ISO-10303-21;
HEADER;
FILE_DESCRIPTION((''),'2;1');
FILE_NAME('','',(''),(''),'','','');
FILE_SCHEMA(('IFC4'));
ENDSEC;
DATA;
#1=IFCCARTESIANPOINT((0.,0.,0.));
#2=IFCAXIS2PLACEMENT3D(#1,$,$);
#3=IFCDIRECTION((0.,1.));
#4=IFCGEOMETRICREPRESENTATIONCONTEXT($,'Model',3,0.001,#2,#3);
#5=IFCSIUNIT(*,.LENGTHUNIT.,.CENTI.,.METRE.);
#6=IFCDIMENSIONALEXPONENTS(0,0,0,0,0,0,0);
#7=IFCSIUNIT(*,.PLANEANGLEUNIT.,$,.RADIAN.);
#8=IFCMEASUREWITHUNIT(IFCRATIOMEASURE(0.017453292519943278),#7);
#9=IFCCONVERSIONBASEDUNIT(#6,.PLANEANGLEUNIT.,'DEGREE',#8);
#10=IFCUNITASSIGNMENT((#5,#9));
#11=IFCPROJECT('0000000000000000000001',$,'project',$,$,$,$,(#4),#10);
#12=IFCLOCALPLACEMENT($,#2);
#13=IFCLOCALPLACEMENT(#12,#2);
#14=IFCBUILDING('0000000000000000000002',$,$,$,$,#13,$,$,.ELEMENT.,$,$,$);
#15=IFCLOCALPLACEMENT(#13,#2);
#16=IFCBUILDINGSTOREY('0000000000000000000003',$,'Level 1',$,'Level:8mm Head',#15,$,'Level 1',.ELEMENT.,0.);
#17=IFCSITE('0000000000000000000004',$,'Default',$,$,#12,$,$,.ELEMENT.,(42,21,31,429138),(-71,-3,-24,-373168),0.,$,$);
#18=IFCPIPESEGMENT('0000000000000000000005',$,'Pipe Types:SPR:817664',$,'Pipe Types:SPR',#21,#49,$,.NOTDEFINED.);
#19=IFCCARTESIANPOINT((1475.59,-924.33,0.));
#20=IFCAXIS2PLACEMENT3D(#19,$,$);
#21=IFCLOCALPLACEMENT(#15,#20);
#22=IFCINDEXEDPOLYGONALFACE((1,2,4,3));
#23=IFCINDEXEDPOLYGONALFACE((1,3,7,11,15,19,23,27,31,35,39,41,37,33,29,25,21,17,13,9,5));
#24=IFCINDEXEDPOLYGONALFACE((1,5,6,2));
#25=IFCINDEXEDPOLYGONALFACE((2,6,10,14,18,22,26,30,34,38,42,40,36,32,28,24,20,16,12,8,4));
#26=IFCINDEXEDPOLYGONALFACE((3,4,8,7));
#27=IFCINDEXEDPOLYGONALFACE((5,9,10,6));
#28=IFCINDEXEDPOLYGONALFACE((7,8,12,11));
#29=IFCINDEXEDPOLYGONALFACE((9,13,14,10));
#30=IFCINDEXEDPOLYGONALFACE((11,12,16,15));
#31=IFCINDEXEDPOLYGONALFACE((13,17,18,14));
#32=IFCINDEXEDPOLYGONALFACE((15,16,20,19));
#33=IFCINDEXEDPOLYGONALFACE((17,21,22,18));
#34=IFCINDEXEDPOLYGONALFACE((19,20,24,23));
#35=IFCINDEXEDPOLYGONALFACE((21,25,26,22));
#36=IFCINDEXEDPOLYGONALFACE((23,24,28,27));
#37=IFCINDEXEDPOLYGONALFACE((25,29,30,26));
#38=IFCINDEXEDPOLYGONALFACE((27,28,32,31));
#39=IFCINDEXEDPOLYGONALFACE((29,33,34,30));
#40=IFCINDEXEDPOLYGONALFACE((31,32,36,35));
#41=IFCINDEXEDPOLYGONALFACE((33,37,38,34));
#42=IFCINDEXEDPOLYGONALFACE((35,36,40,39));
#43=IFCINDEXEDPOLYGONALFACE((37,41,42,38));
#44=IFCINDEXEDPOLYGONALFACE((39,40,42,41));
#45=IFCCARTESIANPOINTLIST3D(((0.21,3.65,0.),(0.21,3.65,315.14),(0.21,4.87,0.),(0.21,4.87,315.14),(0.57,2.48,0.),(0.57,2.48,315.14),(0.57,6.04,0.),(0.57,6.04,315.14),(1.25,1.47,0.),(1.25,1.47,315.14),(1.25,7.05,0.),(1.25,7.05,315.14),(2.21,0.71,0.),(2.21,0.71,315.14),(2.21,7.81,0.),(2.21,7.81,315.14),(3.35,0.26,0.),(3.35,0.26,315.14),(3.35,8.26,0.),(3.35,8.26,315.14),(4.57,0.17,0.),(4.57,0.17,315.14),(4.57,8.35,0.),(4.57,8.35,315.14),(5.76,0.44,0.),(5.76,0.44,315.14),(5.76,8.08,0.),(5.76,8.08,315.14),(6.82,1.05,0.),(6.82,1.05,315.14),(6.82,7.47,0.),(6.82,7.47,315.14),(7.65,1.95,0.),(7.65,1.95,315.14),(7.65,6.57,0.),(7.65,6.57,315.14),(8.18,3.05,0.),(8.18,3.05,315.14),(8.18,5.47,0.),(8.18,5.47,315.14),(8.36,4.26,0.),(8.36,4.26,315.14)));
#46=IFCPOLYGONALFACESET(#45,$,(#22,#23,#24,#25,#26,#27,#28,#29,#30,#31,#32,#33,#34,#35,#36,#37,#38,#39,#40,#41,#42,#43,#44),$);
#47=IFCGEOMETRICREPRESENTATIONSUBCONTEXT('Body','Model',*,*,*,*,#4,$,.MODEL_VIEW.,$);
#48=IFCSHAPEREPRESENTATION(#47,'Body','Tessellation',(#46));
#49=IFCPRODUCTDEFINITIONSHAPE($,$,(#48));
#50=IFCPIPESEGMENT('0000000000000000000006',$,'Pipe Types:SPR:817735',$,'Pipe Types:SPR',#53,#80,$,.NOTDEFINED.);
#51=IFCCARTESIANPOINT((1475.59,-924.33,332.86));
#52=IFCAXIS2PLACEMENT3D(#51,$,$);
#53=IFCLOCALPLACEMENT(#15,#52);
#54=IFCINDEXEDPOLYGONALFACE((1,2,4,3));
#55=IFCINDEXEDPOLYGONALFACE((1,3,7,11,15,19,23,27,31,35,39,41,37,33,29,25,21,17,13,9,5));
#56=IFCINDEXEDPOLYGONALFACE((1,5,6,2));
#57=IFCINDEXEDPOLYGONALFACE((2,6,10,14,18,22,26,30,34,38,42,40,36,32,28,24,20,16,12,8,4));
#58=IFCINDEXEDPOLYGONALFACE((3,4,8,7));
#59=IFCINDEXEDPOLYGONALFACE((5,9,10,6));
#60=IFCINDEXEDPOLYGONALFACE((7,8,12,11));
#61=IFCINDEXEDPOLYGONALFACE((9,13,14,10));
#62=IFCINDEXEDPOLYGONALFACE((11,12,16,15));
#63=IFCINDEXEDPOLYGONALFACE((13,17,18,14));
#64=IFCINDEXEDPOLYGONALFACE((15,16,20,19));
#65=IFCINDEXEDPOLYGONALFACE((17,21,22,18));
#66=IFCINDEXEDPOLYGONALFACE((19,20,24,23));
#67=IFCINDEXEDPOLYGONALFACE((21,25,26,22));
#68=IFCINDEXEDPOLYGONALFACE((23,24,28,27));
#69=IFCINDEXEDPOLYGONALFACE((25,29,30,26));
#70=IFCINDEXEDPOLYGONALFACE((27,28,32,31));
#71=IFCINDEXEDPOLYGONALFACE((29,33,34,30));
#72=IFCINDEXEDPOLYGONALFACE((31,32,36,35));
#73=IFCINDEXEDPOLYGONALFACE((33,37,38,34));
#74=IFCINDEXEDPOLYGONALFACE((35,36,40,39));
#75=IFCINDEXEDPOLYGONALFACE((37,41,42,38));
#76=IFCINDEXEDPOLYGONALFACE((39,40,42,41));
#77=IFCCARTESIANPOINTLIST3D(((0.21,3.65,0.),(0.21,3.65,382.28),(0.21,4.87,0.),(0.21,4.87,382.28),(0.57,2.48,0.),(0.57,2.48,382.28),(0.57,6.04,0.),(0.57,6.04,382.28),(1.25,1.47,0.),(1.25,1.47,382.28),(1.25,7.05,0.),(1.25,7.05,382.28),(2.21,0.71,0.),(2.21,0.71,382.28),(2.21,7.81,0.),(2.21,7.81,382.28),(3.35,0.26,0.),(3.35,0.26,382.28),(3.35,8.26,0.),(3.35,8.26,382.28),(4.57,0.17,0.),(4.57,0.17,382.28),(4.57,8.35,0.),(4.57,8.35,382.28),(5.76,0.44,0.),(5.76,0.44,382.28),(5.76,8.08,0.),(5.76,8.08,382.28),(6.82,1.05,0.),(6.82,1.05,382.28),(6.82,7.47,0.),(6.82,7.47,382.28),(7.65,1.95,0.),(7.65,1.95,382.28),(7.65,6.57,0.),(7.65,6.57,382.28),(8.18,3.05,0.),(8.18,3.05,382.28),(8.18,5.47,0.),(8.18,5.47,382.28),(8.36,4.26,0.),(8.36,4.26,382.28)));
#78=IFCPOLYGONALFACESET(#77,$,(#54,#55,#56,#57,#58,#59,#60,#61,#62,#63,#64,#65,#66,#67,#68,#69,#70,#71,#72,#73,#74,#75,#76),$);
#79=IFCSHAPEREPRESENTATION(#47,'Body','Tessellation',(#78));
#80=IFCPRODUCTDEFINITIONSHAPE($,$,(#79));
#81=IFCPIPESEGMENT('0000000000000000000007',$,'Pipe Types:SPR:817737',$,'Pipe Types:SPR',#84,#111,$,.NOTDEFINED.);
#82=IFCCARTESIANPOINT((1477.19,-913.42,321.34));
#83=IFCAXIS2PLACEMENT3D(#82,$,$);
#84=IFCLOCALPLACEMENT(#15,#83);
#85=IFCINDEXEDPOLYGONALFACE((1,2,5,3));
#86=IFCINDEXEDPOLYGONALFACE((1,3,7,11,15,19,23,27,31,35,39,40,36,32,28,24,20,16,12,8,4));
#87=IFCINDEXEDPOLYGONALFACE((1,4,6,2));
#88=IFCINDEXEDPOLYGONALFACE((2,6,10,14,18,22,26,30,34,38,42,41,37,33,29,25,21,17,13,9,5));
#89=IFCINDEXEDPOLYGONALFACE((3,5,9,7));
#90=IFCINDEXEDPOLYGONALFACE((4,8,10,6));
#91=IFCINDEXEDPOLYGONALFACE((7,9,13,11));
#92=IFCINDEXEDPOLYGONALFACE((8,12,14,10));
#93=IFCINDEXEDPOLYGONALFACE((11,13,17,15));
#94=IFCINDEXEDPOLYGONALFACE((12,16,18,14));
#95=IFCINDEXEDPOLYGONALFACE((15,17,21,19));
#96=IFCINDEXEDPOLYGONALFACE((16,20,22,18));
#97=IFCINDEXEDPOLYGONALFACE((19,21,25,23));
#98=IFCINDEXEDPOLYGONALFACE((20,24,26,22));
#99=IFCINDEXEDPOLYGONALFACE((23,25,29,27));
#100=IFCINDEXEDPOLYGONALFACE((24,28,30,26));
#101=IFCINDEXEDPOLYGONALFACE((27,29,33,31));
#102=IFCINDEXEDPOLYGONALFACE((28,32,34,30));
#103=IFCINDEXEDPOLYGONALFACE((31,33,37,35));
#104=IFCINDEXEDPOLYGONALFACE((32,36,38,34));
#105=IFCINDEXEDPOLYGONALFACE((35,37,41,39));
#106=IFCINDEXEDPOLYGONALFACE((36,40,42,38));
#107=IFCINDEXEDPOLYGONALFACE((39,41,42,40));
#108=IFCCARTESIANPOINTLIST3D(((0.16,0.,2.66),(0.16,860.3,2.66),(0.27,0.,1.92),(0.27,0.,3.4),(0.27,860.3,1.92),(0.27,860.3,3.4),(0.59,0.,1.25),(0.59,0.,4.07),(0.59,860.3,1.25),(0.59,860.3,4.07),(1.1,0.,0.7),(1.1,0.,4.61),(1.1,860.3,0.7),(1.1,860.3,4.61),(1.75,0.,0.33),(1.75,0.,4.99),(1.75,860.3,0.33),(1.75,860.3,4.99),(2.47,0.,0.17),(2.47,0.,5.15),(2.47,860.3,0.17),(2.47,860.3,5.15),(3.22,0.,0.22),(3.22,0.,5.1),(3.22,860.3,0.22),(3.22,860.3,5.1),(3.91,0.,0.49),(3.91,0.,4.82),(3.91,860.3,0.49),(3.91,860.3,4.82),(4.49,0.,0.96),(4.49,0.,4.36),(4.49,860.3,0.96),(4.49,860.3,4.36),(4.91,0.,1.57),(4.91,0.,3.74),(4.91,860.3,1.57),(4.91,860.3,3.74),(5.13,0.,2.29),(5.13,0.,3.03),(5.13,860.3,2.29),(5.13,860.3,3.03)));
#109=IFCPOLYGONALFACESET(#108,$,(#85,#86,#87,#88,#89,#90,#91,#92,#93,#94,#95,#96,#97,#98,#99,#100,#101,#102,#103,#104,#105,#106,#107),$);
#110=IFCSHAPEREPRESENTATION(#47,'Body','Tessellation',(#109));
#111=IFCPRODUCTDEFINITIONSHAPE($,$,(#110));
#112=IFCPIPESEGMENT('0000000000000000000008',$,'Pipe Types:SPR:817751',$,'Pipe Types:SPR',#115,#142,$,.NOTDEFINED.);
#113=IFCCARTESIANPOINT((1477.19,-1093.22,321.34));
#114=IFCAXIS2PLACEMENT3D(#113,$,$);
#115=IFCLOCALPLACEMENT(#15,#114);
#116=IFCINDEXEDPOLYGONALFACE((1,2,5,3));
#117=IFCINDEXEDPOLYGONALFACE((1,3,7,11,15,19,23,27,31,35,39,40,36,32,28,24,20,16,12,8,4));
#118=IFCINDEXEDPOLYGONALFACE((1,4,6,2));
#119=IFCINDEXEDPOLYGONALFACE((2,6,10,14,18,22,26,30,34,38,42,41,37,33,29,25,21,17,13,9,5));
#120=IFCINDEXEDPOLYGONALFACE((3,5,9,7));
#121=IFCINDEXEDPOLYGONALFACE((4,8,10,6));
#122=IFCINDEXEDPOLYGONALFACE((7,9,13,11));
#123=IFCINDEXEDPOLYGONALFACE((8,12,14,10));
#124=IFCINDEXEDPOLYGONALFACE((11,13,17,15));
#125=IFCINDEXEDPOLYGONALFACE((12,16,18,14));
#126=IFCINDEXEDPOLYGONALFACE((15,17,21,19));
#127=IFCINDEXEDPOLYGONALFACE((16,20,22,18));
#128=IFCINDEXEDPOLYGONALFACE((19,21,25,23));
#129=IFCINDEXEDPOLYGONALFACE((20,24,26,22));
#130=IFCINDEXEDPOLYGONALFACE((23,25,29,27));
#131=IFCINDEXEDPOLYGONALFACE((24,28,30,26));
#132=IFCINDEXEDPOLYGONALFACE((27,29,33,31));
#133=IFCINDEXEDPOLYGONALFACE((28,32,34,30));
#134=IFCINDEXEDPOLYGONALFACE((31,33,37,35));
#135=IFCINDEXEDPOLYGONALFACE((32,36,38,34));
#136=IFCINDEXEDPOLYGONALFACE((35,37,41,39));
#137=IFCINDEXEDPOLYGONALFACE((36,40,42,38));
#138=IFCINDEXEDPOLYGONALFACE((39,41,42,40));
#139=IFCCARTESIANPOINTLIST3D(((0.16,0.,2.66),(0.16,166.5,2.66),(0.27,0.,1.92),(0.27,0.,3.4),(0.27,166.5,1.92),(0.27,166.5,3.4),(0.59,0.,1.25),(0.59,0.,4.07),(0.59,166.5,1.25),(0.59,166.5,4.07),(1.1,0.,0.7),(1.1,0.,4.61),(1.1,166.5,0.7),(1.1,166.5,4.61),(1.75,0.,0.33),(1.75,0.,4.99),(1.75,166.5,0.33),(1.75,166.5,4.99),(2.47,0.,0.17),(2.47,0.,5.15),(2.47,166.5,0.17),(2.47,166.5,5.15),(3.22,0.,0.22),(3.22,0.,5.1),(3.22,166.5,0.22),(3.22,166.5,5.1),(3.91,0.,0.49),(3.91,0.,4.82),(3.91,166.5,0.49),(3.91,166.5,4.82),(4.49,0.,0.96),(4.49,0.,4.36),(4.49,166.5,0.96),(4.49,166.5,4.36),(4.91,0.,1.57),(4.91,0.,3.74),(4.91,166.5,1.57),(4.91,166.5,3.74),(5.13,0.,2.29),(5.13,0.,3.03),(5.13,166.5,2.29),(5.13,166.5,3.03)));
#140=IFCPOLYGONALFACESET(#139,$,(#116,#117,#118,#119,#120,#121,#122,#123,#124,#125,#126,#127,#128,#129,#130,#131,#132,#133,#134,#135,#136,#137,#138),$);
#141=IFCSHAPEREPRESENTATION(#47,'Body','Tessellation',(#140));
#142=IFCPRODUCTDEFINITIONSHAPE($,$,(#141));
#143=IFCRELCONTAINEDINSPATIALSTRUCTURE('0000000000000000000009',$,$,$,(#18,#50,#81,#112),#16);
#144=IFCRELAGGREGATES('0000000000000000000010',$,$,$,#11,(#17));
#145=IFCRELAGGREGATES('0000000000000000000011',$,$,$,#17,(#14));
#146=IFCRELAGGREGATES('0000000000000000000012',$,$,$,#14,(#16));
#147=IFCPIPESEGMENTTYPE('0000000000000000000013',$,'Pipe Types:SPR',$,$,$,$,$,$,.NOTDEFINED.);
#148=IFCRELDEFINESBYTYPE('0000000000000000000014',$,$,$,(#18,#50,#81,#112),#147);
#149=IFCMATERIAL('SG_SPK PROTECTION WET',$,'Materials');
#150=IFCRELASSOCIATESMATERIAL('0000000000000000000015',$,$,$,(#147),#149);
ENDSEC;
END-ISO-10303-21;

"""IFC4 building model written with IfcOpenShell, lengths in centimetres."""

from ifc_helpers import new_model, entity, si_unit, converted_unit, direction, frame, frame_2d, origin, origin_2d_with_axis, place, context, subcontext, project, spatial, circle, extrude, material, type_object, element, save


model = new_model("IFC4")

# Units and contexts
model_context = context("Model", 3, precision=0.001, world=origin(), true_north=direction((0.0, 1.0)))
body_context = subcontext(model_context, "Body", "Model", "MODEL_VIEW")
ifc_project = project(units=[si_unit("LENGTHUNIT", "METRE", prefix="CENTI"), converted_unit("PLANEANGLEUNIT", "DEGREE", entity("IfcRatioMeasure", 0.017453292519943278), si_unit("PLANEANGLEUNIT", "RADIAN"), dimensions=[0, 0, 0, 0, 0, 0, 0])], contexts=[model_context])

# Site, building, storey
site_placement = place(None, origin())
site = spatial("IfcSite", under=ifc_project, at=site_placement, Name="Default", CompositionType="ELEMENT", RefLatitude=(42, 21, 31, 429138), RefLongitude=(-71, -3, -24, -373168), RefElevation=0.0)
building_placement = place(site_placement, origin())
building = spatial("IfcBuilding", under=site, at=building_placement, CompositionType="ELEMENT")
storey_placement = place(building_placement, origin())
storey = spatial("IfcBuildingStorey", under=building, at=storey_placement, Name="Level 1", ObjectType="Level:8mm Head", LongName="Level 1", CompositionType="ELEMENT", Elevation=0.0)

# Pipe segments
ifc_material_1 = material(Name="SG_SPK PROTECTION WET", Category="Materials")
pipe_segment_type = type_object("IfcPipeSegmentType", Name="Pipe Types:SPR", PredefinedType="NOTDEFINED", material=ifc_material_1)
pipe_segment_1_placement = place(storey_placement, frame((1475.59, -924.33, 0.0)))
element("IfcPipeSegment", 1, at=pipe_segment_1_placement, inside=storey, type_object=pipe_segment_type, Name="Pipe Types:SPR:817664", ObjectType="Pipe Types:SPR", PredefinedType="NOTDEFINED", context=body_context, shape_type="SweptSolid", body=[
    extrude(circle(Radius=4.1, at=origin_2d_with_axis()), frame((4.26, 4.26, 0.0)), (0.0, 0.0, 1.0), 315.14),
])
pipe_segment_2_placement = place(storey_placement, frame((1475.59, -924.33, 332.86)))
element("IfcPipeSegment", 2, at=pipe_segment_2_placement, inside=storey, type_object=pipe_segment_type, Name="Pipe Types:SPR:817735", ObjectType="Pipe Types:SPR", PredefinedType="NOTDEFINED", context=body_context, shape_type="SweptSolid", body=[
    extrude(circle(Radius=4.1, at=origin_2d_with_axis()), frame((4.26, 4.26, 0.0)), (0.0, 0.0, 1.0), 382.28),
])
pipe_segment_3_placement = place(storey_placement, frame((1477.19, -913.42, 321.34)))
element("IfcPipeSegment", 3, at=pipe_segment_3_placement, inside=storey, type_object=pipe_segment_type, Name="Pipe Types:SPR:817737", ObjectType="Pipe Types:SPR", PredefinedType="NOTDEFINED", context=body_context, shape_type="SweptSolid", body=[
    extrude(circle(Radius=2.5, at=frame_2d((0.0, 0.0), x_axis=(1.0, 0.0))), frame((2.66, 0.0, 2.66), z_axis=(0.0, 1.0, 0.0), x_axis=(-1.0, 0.0, 0.0)), (0.0, 0.0, 1.0), 860.3),
])
pipe_segment_4_placement = place(storey_placement, frame((1477.19, -1093.22, 321.34)))
element("IfcPipeSegment", 4, at=pipe_segment_4_placement, inside=storey, type_object=pipe_segment_type, Name="Pipe Types:SPR:817751", ObjectType="Pipe Types:SPR", PredefinedType="NOTDEFINED", context=body_context, shape_type="SweptSolid", body=[
    extrude(circle(Radius=2.5, at=origin_2d_with_axis()), frame((2.66, 0.0, 2.66), z_axis=(0.0, 1.0, 0.0), x_axis=(-1.0, 0.0, 0.0)), (0.0, 0.0, 1.0), 166.5),
])

save(model, "model.ifc")
